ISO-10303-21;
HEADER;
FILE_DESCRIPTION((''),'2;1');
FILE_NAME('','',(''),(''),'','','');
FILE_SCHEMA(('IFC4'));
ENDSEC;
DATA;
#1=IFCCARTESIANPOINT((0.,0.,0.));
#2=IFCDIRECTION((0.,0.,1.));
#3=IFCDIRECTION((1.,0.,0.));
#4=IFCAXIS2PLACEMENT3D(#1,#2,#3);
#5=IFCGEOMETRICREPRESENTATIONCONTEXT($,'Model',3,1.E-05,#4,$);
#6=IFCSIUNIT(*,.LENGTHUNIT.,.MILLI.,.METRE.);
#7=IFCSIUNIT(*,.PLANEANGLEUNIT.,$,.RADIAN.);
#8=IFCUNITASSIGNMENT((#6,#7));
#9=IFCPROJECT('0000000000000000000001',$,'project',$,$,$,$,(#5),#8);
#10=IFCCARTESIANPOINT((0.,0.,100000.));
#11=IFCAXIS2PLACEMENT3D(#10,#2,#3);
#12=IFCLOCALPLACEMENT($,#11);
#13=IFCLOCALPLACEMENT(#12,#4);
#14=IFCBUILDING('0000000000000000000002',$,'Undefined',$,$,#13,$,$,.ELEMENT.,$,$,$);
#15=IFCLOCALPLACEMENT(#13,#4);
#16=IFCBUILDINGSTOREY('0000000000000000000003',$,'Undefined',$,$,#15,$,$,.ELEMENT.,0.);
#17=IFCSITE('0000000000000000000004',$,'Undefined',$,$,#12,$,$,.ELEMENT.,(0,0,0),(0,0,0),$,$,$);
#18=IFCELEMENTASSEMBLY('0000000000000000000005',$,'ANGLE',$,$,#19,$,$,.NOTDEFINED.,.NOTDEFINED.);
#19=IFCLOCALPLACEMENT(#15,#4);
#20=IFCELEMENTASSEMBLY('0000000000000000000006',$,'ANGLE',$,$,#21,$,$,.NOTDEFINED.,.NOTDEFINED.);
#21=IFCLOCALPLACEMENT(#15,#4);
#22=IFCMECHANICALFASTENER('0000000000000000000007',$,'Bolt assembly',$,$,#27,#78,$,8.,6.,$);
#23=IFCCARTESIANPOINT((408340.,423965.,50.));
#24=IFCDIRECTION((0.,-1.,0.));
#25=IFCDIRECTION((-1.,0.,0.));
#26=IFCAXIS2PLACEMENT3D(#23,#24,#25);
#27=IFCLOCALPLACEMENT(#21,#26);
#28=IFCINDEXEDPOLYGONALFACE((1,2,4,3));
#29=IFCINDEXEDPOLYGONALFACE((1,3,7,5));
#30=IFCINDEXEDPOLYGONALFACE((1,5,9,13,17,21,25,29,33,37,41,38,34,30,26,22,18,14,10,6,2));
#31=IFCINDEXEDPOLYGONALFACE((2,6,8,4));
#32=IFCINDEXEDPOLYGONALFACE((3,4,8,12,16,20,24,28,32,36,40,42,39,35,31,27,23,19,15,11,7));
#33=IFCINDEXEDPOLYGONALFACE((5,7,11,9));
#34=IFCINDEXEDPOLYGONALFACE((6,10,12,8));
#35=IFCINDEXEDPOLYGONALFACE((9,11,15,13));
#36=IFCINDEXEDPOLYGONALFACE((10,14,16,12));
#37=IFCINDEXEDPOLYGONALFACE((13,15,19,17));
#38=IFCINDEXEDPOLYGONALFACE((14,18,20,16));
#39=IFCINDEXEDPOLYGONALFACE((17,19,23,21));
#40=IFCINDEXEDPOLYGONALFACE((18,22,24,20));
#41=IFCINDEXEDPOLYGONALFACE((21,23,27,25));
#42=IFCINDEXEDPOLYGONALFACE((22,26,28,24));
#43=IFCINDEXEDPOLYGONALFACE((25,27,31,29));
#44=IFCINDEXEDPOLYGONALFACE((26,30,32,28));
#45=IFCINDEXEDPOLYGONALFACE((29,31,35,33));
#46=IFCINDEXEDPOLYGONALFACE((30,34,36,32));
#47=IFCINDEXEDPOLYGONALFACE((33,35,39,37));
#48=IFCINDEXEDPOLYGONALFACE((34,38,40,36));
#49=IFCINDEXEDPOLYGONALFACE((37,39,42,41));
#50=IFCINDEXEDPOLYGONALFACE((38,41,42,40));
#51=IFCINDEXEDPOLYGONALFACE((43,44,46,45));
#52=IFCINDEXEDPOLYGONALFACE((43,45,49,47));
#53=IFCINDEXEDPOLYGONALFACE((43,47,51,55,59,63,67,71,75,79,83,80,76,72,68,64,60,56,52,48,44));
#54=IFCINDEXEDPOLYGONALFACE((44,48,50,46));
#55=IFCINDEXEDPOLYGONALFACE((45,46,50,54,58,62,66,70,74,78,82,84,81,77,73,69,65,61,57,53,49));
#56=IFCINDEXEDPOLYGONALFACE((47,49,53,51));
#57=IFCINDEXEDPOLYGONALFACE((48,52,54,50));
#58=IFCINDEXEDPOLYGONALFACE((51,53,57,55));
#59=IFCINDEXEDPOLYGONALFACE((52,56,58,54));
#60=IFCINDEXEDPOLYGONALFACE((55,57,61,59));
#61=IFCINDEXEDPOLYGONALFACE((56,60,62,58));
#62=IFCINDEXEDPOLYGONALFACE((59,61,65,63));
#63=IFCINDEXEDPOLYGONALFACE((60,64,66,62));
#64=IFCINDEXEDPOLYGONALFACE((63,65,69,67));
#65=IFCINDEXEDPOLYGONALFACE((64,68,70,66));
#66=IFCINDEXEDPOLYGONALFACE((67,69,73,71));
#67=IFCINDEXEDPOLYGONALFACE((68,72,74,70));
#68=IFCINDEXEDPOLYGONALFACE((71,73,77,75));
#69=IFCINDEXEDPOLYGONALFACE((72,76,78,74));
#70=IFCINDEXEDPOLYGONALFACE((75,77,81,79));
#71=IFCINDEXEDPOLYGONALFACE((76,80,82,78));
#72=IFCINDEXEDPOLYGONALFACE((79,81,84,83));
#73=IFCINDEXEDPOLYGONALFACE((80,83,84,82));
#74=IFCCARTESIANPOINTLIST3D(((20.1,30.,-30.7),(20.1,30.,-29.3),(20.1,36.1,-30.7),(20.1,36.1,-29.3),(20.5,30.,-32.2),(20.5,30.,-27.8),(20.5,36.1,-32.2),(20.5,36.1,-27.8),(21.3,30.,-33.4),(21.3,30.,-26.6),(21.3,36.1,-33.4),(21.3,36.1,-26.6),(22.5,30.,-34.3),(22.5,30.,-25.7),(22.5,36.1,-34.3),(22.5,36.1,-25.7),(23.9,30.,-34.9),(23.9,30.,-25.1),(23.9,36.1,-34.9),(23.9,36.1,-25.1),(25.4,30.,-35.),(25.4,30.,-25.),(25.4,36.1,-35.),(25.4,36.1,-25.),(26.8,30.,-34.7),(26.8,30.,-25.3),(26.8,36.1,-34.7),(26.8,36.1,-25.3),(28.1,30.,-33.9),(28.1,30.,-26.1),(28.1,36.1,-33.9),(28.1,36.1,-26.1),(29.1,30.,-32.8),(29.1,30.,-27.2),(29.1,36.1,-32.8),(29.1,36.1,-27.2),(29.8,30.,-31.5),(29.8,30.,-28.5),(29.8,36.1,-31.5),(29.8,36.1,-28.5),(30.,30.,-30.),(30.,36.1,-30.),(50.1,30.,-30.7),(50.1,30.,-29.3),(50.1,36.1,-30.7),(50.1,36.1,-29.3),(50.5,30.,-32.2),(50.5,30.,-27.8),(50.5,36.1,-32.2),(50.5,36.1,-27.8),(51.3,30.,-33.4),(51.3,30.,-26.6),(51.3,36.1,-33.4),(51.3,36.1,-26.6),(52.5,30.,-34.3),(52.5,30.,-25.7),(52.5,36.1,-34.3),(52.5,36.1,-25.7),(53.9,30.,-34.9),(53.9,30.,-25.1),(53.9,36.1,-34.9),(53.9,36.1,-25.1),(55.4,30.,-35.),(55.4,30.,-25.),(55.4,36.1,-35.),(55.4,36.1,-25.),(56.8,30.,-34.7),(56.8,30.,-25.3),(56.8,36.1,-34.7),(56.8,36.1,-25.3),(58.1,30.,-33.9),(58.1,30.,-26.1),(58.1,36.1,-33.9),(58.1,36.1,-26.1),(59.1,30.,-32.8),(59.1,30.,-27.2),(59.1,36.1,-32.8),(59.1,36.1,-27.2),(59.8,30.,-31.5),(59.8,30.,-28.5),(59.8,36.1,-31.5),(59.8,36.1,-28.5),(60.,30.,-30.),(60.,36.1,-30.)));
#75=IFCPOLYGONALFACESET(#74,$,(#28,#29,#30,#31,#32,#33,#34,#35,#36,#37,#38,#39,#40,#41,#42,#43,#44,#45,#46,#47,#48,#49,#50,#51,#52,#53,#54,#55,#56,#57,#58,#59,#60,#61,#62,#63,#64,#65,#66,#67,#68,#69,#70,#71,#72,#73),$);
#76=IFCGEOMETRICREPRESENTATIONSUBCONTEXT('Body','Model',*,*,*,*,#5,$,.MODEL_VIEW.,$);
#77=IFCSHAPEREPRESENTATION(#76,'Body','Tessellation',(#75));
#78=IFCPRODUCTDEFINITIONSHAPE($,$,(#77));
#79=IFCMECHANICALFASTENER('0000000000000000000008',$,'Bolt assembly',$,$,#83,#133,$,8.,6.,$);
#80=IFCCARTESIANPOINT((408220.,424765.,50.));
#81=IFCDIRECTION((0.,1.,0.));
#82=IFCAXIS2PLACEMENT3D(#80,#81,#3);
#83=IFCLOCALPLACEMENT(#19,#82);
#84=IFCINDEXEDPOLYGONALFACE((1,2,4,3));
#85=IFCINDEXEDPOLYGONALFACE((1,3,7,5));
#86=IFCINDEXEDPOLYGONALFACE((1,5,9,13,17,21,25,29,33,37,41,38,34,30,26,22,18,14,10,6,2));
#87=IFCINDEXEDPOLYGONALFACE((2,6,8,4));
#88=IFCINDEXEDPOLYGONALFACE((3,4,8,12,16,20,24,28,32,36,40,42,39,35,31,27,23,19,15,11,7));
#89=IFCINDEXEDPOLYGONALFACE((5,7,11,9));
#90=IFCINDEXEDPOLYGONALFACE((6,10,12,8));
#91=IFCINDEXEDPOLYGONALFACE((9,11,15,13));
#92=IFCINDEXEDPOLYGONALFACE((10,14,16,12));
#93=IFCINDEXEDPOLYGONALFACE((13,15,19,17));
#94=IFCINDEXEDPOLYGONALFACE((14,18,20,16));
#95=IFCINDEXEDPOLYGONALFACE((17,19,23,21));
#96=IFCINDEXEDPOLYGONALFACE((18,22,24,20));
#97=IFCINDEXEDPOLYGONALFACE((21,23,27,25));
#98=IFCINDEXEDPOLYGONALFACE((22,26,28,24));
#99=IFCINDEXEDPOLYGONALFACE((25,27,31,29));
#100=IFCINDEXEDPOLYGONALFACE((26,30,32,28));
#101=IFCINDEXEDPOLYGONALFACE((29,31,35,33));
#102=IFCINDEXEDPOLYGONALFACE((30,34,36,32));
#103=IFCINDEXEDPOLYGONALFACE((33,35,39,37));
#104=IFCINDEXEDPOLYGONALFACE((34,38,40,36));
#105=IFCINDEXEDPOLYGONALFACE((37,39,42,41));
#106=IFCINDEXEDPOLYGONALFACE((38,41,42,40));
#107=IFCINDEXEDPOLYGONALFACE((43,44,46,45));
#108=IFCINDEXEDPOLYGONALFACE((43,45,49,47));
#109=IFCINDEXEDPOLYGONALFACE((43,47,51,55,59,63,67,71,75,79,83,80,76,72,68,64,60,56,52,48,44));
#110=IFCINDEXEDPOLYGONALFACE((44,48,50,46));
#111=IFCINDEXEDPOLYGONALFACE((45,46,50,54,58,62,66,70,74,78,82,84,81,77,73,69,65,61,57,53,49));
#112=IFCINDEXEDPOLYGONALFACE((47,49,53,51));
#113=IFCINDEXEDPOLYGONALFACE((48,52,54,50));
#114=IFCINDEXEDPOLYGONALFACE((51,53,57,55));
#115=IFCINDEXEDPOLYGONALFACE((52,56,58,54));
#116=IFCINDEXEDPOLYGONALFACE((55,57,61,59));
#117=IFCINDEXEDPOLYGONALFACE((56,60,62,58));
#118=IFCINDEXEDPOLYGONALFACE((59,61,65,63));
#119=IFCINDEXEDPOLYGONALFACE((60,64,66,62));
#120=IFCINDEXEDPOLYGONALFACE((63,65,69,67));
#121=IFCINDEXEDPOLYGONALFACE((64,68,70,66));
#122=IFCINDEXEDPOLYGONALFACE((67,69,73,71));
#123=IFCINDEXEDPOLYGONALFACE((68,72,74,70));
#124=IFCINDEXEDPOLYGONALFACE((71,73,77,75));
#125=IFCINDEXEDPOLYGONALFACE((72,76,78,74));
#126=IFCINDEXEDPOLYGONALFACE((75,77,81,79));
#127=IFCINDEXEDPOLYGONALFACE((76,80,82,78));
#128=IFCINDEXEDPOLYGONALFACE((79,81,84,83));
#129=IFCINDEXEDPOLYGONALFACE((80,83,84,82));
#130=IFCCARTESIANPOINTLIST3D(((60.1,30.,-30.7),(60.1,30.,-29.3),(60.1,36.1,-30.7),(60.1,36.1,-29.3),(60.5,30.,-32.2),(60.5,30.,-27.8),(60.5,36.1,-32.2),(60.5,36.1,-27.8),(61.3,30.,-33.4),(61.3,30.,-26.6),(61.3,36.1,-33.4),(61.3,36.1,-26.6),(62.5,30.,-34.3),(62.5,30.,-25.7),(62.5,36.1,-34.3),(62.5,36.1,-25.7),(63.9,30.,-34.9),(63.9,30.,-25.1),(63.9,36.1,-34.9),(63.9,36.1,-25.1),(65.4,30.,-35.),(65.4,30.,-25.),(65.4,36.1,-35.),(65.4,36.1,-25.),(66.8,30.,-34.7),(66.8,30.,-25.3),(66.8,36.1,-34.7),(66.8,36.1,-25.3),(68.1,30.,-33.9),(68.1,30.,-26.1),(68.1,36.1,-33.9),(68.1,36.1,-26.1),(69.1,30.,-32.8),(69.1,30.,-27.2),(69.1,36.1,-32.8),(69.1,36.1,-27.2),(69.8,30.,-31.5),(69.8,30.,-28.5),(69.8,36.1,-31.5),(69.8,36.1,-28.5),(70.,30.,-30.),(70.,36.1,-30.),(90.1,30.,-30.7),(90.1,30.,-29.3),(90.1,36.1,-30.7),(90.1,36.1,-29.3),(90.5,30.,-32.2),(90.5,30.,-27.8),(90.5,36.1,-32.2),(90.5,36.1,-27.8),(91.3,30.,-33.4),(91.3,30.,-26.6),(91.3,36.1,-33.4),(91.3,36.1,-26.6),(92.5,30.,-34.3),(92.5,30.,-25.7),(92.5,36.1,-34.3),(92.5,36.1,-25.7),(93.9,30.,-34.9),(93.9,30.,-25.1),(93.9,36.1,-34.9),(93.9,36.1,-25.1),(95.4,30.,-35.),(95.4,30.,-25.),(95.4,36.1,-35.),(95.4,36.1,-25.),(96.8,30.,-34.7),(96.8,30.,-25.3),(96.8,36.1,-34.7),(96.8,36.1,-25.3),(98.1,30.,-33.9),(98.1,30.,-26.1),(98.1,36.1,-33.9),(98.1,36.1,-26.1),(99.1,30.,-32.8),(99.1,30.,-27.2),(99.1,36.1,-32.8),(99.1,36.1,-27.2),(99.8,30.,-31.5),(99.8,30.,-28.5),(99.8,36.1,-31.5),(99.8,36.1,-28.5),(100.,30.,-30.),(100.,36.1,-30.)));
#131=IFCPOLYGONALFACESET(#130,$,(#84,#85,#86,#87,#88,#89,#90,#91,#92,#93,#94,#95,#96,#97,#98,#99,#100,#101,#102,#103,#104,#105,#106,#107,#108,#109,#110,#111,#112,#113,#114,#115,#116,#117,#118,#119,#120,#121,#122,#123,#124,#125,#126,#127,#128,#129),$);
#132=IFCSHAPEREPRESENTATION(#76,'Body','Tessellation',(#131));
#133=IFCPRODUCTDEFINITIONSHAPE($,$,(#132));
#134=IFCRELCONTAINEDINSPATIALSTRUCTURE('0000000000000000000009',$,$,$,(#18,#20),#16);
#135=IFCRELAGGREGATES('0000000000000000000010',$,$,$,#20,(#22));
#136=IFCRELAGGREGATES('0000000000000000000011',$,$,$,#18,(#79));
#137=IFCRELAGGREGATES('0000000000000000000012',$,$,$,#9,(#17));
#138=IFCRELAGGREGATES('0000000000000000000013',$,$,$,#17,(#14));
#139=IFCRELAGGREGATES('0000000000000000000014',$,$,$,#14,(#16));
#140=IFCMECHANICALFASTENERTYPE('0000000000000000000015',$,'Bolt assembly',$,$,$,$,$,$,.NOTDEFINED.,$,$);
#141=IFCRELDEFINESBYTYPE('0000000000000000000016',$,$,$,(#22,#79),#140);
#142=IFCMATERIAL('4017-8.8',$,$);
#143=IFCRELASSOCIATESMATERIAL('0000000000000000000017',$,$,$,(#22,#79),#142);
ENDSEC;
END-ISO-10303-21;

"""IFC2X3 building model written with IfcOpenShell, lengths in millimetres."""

from ifc_helpers import new_model, si_unit, frame, origin_with_axes, origin_2d_with_axis, place, context, subcontext, project, spatial, circle, extrude, source, transform, mapped, material, type_object, element, aggregate, save


model = new_model("IFC2X3")

# Units and contexts
model_context = context("Model", 3, precision=1e-05, world=origin_with_axes())
body_context = subcontext(model_context, "Body", "Model", "MODEL_VIEW")
ifc_project = project(units=[si_unit("LENGTHUNIT", "METRE", prefix="MILLI"), si_unit("PLANEANGLEUNIT", "RADIAN")], contexts=[model_context])

# Site, building, storey
site_placement = place(None, frame((0.0, 0.0, 100000.0), z_axis=(0.0, 0.0, 1.0), x_axis=(1.0, 0.0, 0.0)))
site = spatial("IfcSite", under=ifc_project, at=site_placement, Name="Undefined", CompositionType="ELEMENT", RefLatitude=(0, 0, 0), RefLongitude=(0, 0, 0))
building_placement = place(site_placement, origin_with_axes())
building = spatial("IfcBuilding", under=site, at=building_placement, Name="Undefined", CompositionType="ELEMENT")
storey_placement = place(building_placement, origin_with_axes())
storey = spatial("IfcBuildingStorey", under=building, at=storey_placement, Name="Undefined", CompositionType="ELEMENT", Elevation=0.0)

# Element assembly
assembly_1_placement = place(storey_placement, origin_with_axes())
assembly_1 = element("IfcElementAssembly", 1, at=assembly_1_placement, inside=storey, Name="ANGLE", AssemblyPlace="NOTDEFINED", PredefinedType="NOTDEFINED")

# Shared definitions
ifc_material_1 = material(Name="4017-8.8")
mechanical_fastener_type = type_object("IfcMechanicalFastenerType", Name="Bolt assembly")

# Element assembly
assembly_2_placement = place(storey_placement, origin_with_axes())
assembly_2 = element("IfcElementAssembly", 2, at=assembly_2_placement, inside=storey, Name="ANGLE", AssemblyPlace="NOTDEFINED", PredefinedType="NOTDEFINED")

# Mechanical fasteners
shared_shape_1 = source(origin_with_axes(), body_context, "Body", "SweptSolid", [
    extrude(circle(Radius=5.0, at=origin_2d_with_axis()), frame((0.0, 30.0, 0.0), z_axis=(0.0, 1.0, 0.0), x_axis=(1.0, 0.0, 0.0)), (0.0, 0.0, 1.0), 6.1),
])
mechanical_fastener_1_placement = place(assembly_2_placement, frame((408340.0, 423965.0, 50.0), z_axis=(0.0, -1.0, 0.0), x_axis=(-1.0, 0.0, 0.0)))
mechanical_fastener_1 = element("IfcMechanicalFastener", 3, at=mechanical_fastener_1_placement, type_object=mechanical_fastener_type, material=ifc_material_1, Name="Bolt assembly", NominalDiameter=8.0, NominalLength=6.0, context=body_context, shape_type="MappedRepresentation", body=[
    mapped(shared_shape_1, transform((25.0, 0.0, -30.0))),
    mapped(shared_shape_1, transform((55.0, 0.0, -30.0))),
])
aggregate(assembly_2, [mechanical_fastener_1])
mechanical_fastener_2_placement = place(assembly_1_placement, frame((408220.0, 424765.0, 50.0), z_axis=(0.0, 1.0, 0.0), x_axis=(1.0, 0.0, 0.0)))
mechanical_fastener_2 = element("IfcMechanicalFastener", 4, at=mechanical_fastener_2_placement, type_object=mechanical_fastener_type, material=ifc_material_1, Name="Bolt assembly", NominalDiameter=8.0, NominalLength=6.0, context=body_context, shape_type="MappedRepresentation", body=[
    mapped(shared_shape_1, transform((95.0, 0.0, -30.0))),
    mapped(shared_shape_1, transform((65.0, 0.0, -30.0))),
])
aggregate(assembly_1, [mechanical_fastener_2])

save(model, "model.ifc")
